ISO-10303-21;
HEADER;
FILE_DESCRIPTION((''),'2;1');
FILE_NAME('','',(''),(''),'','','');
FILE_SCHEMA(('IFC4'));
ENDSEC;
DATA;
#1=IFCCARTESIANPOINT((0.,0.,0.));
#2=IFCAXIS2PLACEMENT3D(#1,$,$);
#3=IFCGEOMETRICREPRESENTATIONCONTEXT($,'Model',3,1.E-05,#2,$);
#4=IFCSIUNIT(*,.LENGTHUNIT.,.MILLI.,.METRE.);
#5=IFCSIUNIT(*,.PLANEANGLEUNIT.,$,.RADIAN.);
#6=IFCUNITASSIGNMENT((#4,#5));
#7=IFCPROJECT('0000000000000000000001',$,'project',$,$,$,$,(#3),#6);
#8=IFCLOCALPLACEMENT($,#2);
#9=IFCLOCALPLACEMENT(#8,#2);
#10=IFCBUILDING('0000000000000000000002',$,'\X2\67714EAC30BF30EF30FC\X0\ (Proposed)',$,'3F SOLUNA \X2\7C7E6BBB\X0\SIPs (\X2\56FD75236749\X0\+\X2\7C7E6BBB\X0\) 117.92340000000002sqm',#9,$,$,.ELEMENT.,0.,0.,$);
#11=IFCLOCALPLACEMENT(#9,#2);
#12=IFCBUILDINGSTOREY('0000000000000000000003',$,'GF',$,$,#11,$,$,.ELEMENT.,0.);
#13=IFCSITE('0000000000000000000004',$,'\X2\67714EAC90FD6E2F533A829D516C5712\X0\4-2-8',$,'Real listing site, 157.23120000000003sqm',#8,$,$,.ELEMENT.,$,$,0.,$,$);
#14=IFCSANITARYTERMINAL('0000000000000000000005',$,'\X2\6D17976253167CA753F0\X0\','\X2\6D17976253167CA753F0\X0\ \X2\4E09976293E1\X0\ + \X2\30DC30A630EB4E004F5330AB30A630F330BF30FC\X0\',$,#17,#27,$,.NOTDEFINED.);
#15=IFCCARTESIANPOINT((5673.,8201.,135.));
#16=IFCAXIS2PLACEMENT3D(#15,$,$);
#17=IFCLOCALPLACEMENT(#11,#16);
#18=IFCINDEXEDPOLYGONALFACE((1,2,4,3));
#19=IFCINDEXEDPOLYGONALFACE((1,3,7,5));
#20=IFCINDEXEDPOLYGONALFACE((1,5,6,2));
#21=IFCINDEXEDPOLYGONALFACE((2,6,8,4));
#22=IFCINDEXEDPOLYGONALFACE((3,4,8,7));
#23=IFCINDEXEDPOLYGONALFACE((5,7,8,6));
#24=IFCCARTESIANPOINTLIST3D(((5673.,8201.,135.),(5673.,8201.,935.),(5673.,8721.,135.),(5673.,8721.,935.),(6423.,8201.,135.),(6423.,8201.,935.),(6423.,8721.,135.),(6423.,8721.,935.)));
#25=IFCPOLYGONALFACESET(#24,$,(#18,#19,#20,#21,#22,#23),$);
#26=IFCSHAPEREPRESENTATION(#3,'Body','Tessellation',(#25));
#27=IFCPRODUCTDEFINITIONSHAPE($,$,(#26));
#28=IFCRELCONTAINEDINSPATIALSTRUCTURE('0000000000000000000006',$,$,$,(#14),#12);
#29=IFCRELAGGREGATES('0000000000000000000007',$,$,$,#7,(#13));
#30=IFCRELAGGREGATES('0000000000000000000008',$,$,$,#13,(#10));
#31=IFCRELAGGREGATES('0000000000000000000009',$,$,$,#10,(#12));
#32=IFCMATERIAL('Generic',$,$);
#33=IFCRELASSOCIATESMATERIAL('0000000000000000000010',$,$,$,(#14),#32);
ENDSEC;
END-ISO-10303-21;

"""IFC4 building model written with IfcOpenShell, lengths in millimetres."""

from ifc_helpers import new_model, si_unit, frame, frame_2d, origin, place, context, project, spatial, rectangle, extrude, material, element, save


model = new_model("IFC4")

# Units and contexts
model_context = context("Model", 3, precision=1e-05, world=origin())
ifc_project = project(units=[si_unit("LENGTHUNIT", "METRE", prefix="MILLI"), si_unit("PLANEANGLEUNIT", "RADIAN")], contexts=[model_context])

# Site, building, storey
site_placement = place(None, origin())
site = spatial("IfcSite", under=ifc_project, at=site_placement, Name="東京都港区芝公園4-2-8", ObjectType="Real listing site, 157.23120000000003sqm", CompositionType="ELEMENT", RefElevation=0.0)
building_placement = place(site_placement, origin())
building = spatial("IfcBuilding", under=site, at=building_placement, Name="東京タワー (Proposed)", ObjectType="3F SOLUNA 籾殻SIPs (国産杉+籾殻) 117.92340000000002sqm", CompositionType="ELEMENT", ElevationOfRefHeight=0.0, ElevationOfTerrain=0.0)
storey_placement = place(building_placement, origin())
storey = spatial("IfcBuildingStorey", under=building, at=storey_placement, Name="GF", CompositionType="ELEMENT", Elevation=0.0)

# Shared definitions
ifc_material_1 = material(Name="Generic")

# Sanitary terminal
sanitary_terminal_1_placement = place(storey_placement, frame((5673.0, 8201.0, 135.0)))
element("IfcSanitaryTerminal", 1, at=sanitary_terminal_1_placement, inside=storey, material=ifc_material_1, Name="洗面化粧台", Description="洗面化粧台 三面鏡 + ボウル一体カウンター", PredefinedType="NOTDEFINED", context=model_context, shape_type="SweptSolid", body=[
    extrude(rectangle(XDim=750.0, YDim=520.0, at=frame_2d((375.0, 260.0))), frame((5673.0, 8201.0, 135.0)), (0.0, 0.0, 1.0), 800.0),
])

save(model, "model.ifc")
